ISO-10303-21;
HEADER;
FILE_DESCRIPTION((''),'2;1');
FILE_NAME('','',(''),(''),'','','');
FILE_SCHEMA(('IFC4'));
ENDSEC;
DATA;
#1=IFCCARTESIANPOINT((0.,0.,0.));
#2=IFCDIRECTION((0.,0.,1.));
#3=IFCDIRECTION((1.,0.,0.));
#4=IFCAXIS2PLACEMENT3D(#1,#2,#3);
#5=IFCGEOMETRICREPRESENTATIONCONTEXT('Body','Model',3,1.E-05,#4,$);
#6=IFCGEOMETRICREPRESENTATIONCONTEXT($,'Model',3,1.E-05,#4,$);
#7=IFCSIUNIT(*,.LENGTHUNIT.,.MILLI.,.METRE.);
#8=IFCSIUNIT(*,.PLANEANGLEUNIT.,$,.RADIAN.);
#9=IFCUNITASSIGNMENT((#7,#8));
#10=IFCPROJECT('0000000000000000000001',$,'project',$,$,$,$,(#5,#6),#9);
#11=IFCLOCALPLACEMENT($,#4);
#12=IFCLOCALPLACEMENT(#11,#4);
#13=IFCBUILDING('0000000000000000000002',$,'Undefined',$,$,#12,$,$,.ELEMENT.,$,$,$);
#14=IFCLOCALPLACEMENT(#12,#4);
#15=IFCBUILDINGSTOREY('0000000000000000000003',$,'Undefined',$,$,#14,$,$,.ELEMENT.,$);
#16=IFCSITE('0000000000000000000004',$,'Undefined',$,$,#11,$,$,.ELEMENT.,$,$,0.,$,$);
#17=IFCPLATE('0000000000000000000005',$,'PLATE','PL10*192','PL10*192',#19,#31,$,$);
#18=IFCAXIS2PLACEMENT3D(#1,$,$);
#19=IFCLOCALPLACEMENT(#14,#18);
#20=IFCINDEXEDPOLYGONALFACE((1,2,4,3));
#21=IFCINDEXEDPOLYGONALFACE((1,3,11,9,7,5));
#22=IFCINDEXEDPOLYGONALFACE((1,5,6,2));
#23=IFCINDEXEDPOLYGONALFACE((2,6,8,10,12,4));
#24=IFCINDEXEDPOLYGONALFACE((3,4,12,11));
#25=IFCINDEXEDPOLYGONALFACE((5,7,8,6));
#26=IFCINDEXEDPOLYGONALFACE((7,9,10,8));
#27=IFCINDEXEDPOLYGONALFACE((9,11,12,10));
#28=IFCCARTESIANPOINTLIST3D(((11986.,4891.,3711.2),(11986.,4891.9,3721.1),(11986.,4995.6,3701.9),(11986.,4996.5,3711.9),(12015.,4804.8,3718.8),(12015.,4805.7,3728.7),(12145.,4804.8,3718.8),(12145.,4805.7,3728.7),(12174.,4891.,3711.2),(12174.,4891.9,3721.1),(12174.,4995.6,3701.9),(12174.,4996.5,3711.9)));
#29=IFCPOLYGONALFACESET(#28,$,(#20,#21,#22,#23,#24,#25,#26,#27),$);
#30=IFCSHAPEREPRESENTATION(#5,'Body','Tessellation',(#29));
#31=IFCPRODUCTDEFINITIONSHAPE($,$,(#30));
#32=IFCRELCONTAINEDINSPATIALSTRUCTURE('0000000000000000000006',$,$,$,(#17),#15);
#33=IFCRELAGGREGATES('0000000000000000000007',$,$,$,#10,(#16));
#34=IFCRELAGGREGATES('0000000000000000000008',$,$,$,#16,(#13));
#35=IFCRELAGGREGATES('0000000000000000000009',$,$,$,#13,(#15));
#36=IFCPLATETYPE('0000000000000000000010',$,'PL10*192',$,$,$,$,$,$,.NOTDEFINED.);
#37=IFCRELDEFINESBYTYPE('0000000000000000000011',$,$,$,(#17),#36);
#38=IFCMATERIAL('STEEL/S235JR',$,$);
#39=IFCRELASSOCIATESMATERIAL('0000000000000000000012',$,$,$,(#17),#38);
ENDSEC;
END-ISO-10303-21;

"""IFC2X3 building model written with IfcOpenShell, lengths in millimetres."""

from ifc_helpers import new_model, si_unit, frame, origin_with_axes, place, context, project, spatial, polyline, outline, extrude, material, type_object, element, save


model = new_model("IFC2X3")

# Units and contexts
model_context_1 = context("Model", 3, precision=1e-05, world=origin_with_axes(), identifier="Body")
model_context_2 = context("Model", 3, precision=1e-05, world=origin_with_axes())
ifc_project = project(units=[si_unit("LENGTHUNIT", "METRE", prefix="MILLI"), si_unit("PLANEANGLEUNIT", "RADIAN")], contexts=[model_context_1, model_context_2])

# Site, building, storey
site_placement = place(None, origin_with_axes())
site = spatial("IfcSite", under=ifc_project, at=site_placement, Name="Undefined", CompositionType="ELEMENT", RefElevation=0.0)
building_placement = place(site_placement, origin_with_axes())
building = spatial("IfcBuilding", under=site, at=building_placement, Name="Undefined", CompositionType="ELEMENT")
storey_placement = place(building_placement, origin_with_axes())
storey = spatial("IfcBuildingStorey", under=building, at=storey_placement, Name="Undefined", CompositionType="ELEMENT")

# Shared definitions
ifc_material = material(Name="STEEL/S235JR")

# Plate
plate_type_1 = type_object("IfcPlateType", Name="PL10*192", PredefinedType="NOTDEFINED")
plate_1_placement = place(storey_placement, frame((12015.0, 4805.3, 3723.8), z_axis=(0.0, -0.08801, -0.99612), x_axis=(-0.317772, 0.944488, -0.083449)))
element("IfcPlate", 1, at=plate_1_placement, inside=storey, type_object=plate_type_1, material=ifc_material, Name="PLATE", Description="PL10*192", ObjectType="PL10*192", context=model_context_1, shape_type="SweptSolid", body=[
    extrude(outline(polyline([(0.0, 0.0), (91.3, 0.0), (190.8, 33.4), (131.1, 211.6), (31.5, 178.3), (-41.3, 123.3), (0.0, 0.0)])), frame((0.0, 0.0, -5.0), z_axis=(0.0, 0.0, 1.0), x_axis=(1.0, 0.0, 0.0)), (0.0, 0.0, 1.0), 10.0),
])

save(model, "model.ifc")
